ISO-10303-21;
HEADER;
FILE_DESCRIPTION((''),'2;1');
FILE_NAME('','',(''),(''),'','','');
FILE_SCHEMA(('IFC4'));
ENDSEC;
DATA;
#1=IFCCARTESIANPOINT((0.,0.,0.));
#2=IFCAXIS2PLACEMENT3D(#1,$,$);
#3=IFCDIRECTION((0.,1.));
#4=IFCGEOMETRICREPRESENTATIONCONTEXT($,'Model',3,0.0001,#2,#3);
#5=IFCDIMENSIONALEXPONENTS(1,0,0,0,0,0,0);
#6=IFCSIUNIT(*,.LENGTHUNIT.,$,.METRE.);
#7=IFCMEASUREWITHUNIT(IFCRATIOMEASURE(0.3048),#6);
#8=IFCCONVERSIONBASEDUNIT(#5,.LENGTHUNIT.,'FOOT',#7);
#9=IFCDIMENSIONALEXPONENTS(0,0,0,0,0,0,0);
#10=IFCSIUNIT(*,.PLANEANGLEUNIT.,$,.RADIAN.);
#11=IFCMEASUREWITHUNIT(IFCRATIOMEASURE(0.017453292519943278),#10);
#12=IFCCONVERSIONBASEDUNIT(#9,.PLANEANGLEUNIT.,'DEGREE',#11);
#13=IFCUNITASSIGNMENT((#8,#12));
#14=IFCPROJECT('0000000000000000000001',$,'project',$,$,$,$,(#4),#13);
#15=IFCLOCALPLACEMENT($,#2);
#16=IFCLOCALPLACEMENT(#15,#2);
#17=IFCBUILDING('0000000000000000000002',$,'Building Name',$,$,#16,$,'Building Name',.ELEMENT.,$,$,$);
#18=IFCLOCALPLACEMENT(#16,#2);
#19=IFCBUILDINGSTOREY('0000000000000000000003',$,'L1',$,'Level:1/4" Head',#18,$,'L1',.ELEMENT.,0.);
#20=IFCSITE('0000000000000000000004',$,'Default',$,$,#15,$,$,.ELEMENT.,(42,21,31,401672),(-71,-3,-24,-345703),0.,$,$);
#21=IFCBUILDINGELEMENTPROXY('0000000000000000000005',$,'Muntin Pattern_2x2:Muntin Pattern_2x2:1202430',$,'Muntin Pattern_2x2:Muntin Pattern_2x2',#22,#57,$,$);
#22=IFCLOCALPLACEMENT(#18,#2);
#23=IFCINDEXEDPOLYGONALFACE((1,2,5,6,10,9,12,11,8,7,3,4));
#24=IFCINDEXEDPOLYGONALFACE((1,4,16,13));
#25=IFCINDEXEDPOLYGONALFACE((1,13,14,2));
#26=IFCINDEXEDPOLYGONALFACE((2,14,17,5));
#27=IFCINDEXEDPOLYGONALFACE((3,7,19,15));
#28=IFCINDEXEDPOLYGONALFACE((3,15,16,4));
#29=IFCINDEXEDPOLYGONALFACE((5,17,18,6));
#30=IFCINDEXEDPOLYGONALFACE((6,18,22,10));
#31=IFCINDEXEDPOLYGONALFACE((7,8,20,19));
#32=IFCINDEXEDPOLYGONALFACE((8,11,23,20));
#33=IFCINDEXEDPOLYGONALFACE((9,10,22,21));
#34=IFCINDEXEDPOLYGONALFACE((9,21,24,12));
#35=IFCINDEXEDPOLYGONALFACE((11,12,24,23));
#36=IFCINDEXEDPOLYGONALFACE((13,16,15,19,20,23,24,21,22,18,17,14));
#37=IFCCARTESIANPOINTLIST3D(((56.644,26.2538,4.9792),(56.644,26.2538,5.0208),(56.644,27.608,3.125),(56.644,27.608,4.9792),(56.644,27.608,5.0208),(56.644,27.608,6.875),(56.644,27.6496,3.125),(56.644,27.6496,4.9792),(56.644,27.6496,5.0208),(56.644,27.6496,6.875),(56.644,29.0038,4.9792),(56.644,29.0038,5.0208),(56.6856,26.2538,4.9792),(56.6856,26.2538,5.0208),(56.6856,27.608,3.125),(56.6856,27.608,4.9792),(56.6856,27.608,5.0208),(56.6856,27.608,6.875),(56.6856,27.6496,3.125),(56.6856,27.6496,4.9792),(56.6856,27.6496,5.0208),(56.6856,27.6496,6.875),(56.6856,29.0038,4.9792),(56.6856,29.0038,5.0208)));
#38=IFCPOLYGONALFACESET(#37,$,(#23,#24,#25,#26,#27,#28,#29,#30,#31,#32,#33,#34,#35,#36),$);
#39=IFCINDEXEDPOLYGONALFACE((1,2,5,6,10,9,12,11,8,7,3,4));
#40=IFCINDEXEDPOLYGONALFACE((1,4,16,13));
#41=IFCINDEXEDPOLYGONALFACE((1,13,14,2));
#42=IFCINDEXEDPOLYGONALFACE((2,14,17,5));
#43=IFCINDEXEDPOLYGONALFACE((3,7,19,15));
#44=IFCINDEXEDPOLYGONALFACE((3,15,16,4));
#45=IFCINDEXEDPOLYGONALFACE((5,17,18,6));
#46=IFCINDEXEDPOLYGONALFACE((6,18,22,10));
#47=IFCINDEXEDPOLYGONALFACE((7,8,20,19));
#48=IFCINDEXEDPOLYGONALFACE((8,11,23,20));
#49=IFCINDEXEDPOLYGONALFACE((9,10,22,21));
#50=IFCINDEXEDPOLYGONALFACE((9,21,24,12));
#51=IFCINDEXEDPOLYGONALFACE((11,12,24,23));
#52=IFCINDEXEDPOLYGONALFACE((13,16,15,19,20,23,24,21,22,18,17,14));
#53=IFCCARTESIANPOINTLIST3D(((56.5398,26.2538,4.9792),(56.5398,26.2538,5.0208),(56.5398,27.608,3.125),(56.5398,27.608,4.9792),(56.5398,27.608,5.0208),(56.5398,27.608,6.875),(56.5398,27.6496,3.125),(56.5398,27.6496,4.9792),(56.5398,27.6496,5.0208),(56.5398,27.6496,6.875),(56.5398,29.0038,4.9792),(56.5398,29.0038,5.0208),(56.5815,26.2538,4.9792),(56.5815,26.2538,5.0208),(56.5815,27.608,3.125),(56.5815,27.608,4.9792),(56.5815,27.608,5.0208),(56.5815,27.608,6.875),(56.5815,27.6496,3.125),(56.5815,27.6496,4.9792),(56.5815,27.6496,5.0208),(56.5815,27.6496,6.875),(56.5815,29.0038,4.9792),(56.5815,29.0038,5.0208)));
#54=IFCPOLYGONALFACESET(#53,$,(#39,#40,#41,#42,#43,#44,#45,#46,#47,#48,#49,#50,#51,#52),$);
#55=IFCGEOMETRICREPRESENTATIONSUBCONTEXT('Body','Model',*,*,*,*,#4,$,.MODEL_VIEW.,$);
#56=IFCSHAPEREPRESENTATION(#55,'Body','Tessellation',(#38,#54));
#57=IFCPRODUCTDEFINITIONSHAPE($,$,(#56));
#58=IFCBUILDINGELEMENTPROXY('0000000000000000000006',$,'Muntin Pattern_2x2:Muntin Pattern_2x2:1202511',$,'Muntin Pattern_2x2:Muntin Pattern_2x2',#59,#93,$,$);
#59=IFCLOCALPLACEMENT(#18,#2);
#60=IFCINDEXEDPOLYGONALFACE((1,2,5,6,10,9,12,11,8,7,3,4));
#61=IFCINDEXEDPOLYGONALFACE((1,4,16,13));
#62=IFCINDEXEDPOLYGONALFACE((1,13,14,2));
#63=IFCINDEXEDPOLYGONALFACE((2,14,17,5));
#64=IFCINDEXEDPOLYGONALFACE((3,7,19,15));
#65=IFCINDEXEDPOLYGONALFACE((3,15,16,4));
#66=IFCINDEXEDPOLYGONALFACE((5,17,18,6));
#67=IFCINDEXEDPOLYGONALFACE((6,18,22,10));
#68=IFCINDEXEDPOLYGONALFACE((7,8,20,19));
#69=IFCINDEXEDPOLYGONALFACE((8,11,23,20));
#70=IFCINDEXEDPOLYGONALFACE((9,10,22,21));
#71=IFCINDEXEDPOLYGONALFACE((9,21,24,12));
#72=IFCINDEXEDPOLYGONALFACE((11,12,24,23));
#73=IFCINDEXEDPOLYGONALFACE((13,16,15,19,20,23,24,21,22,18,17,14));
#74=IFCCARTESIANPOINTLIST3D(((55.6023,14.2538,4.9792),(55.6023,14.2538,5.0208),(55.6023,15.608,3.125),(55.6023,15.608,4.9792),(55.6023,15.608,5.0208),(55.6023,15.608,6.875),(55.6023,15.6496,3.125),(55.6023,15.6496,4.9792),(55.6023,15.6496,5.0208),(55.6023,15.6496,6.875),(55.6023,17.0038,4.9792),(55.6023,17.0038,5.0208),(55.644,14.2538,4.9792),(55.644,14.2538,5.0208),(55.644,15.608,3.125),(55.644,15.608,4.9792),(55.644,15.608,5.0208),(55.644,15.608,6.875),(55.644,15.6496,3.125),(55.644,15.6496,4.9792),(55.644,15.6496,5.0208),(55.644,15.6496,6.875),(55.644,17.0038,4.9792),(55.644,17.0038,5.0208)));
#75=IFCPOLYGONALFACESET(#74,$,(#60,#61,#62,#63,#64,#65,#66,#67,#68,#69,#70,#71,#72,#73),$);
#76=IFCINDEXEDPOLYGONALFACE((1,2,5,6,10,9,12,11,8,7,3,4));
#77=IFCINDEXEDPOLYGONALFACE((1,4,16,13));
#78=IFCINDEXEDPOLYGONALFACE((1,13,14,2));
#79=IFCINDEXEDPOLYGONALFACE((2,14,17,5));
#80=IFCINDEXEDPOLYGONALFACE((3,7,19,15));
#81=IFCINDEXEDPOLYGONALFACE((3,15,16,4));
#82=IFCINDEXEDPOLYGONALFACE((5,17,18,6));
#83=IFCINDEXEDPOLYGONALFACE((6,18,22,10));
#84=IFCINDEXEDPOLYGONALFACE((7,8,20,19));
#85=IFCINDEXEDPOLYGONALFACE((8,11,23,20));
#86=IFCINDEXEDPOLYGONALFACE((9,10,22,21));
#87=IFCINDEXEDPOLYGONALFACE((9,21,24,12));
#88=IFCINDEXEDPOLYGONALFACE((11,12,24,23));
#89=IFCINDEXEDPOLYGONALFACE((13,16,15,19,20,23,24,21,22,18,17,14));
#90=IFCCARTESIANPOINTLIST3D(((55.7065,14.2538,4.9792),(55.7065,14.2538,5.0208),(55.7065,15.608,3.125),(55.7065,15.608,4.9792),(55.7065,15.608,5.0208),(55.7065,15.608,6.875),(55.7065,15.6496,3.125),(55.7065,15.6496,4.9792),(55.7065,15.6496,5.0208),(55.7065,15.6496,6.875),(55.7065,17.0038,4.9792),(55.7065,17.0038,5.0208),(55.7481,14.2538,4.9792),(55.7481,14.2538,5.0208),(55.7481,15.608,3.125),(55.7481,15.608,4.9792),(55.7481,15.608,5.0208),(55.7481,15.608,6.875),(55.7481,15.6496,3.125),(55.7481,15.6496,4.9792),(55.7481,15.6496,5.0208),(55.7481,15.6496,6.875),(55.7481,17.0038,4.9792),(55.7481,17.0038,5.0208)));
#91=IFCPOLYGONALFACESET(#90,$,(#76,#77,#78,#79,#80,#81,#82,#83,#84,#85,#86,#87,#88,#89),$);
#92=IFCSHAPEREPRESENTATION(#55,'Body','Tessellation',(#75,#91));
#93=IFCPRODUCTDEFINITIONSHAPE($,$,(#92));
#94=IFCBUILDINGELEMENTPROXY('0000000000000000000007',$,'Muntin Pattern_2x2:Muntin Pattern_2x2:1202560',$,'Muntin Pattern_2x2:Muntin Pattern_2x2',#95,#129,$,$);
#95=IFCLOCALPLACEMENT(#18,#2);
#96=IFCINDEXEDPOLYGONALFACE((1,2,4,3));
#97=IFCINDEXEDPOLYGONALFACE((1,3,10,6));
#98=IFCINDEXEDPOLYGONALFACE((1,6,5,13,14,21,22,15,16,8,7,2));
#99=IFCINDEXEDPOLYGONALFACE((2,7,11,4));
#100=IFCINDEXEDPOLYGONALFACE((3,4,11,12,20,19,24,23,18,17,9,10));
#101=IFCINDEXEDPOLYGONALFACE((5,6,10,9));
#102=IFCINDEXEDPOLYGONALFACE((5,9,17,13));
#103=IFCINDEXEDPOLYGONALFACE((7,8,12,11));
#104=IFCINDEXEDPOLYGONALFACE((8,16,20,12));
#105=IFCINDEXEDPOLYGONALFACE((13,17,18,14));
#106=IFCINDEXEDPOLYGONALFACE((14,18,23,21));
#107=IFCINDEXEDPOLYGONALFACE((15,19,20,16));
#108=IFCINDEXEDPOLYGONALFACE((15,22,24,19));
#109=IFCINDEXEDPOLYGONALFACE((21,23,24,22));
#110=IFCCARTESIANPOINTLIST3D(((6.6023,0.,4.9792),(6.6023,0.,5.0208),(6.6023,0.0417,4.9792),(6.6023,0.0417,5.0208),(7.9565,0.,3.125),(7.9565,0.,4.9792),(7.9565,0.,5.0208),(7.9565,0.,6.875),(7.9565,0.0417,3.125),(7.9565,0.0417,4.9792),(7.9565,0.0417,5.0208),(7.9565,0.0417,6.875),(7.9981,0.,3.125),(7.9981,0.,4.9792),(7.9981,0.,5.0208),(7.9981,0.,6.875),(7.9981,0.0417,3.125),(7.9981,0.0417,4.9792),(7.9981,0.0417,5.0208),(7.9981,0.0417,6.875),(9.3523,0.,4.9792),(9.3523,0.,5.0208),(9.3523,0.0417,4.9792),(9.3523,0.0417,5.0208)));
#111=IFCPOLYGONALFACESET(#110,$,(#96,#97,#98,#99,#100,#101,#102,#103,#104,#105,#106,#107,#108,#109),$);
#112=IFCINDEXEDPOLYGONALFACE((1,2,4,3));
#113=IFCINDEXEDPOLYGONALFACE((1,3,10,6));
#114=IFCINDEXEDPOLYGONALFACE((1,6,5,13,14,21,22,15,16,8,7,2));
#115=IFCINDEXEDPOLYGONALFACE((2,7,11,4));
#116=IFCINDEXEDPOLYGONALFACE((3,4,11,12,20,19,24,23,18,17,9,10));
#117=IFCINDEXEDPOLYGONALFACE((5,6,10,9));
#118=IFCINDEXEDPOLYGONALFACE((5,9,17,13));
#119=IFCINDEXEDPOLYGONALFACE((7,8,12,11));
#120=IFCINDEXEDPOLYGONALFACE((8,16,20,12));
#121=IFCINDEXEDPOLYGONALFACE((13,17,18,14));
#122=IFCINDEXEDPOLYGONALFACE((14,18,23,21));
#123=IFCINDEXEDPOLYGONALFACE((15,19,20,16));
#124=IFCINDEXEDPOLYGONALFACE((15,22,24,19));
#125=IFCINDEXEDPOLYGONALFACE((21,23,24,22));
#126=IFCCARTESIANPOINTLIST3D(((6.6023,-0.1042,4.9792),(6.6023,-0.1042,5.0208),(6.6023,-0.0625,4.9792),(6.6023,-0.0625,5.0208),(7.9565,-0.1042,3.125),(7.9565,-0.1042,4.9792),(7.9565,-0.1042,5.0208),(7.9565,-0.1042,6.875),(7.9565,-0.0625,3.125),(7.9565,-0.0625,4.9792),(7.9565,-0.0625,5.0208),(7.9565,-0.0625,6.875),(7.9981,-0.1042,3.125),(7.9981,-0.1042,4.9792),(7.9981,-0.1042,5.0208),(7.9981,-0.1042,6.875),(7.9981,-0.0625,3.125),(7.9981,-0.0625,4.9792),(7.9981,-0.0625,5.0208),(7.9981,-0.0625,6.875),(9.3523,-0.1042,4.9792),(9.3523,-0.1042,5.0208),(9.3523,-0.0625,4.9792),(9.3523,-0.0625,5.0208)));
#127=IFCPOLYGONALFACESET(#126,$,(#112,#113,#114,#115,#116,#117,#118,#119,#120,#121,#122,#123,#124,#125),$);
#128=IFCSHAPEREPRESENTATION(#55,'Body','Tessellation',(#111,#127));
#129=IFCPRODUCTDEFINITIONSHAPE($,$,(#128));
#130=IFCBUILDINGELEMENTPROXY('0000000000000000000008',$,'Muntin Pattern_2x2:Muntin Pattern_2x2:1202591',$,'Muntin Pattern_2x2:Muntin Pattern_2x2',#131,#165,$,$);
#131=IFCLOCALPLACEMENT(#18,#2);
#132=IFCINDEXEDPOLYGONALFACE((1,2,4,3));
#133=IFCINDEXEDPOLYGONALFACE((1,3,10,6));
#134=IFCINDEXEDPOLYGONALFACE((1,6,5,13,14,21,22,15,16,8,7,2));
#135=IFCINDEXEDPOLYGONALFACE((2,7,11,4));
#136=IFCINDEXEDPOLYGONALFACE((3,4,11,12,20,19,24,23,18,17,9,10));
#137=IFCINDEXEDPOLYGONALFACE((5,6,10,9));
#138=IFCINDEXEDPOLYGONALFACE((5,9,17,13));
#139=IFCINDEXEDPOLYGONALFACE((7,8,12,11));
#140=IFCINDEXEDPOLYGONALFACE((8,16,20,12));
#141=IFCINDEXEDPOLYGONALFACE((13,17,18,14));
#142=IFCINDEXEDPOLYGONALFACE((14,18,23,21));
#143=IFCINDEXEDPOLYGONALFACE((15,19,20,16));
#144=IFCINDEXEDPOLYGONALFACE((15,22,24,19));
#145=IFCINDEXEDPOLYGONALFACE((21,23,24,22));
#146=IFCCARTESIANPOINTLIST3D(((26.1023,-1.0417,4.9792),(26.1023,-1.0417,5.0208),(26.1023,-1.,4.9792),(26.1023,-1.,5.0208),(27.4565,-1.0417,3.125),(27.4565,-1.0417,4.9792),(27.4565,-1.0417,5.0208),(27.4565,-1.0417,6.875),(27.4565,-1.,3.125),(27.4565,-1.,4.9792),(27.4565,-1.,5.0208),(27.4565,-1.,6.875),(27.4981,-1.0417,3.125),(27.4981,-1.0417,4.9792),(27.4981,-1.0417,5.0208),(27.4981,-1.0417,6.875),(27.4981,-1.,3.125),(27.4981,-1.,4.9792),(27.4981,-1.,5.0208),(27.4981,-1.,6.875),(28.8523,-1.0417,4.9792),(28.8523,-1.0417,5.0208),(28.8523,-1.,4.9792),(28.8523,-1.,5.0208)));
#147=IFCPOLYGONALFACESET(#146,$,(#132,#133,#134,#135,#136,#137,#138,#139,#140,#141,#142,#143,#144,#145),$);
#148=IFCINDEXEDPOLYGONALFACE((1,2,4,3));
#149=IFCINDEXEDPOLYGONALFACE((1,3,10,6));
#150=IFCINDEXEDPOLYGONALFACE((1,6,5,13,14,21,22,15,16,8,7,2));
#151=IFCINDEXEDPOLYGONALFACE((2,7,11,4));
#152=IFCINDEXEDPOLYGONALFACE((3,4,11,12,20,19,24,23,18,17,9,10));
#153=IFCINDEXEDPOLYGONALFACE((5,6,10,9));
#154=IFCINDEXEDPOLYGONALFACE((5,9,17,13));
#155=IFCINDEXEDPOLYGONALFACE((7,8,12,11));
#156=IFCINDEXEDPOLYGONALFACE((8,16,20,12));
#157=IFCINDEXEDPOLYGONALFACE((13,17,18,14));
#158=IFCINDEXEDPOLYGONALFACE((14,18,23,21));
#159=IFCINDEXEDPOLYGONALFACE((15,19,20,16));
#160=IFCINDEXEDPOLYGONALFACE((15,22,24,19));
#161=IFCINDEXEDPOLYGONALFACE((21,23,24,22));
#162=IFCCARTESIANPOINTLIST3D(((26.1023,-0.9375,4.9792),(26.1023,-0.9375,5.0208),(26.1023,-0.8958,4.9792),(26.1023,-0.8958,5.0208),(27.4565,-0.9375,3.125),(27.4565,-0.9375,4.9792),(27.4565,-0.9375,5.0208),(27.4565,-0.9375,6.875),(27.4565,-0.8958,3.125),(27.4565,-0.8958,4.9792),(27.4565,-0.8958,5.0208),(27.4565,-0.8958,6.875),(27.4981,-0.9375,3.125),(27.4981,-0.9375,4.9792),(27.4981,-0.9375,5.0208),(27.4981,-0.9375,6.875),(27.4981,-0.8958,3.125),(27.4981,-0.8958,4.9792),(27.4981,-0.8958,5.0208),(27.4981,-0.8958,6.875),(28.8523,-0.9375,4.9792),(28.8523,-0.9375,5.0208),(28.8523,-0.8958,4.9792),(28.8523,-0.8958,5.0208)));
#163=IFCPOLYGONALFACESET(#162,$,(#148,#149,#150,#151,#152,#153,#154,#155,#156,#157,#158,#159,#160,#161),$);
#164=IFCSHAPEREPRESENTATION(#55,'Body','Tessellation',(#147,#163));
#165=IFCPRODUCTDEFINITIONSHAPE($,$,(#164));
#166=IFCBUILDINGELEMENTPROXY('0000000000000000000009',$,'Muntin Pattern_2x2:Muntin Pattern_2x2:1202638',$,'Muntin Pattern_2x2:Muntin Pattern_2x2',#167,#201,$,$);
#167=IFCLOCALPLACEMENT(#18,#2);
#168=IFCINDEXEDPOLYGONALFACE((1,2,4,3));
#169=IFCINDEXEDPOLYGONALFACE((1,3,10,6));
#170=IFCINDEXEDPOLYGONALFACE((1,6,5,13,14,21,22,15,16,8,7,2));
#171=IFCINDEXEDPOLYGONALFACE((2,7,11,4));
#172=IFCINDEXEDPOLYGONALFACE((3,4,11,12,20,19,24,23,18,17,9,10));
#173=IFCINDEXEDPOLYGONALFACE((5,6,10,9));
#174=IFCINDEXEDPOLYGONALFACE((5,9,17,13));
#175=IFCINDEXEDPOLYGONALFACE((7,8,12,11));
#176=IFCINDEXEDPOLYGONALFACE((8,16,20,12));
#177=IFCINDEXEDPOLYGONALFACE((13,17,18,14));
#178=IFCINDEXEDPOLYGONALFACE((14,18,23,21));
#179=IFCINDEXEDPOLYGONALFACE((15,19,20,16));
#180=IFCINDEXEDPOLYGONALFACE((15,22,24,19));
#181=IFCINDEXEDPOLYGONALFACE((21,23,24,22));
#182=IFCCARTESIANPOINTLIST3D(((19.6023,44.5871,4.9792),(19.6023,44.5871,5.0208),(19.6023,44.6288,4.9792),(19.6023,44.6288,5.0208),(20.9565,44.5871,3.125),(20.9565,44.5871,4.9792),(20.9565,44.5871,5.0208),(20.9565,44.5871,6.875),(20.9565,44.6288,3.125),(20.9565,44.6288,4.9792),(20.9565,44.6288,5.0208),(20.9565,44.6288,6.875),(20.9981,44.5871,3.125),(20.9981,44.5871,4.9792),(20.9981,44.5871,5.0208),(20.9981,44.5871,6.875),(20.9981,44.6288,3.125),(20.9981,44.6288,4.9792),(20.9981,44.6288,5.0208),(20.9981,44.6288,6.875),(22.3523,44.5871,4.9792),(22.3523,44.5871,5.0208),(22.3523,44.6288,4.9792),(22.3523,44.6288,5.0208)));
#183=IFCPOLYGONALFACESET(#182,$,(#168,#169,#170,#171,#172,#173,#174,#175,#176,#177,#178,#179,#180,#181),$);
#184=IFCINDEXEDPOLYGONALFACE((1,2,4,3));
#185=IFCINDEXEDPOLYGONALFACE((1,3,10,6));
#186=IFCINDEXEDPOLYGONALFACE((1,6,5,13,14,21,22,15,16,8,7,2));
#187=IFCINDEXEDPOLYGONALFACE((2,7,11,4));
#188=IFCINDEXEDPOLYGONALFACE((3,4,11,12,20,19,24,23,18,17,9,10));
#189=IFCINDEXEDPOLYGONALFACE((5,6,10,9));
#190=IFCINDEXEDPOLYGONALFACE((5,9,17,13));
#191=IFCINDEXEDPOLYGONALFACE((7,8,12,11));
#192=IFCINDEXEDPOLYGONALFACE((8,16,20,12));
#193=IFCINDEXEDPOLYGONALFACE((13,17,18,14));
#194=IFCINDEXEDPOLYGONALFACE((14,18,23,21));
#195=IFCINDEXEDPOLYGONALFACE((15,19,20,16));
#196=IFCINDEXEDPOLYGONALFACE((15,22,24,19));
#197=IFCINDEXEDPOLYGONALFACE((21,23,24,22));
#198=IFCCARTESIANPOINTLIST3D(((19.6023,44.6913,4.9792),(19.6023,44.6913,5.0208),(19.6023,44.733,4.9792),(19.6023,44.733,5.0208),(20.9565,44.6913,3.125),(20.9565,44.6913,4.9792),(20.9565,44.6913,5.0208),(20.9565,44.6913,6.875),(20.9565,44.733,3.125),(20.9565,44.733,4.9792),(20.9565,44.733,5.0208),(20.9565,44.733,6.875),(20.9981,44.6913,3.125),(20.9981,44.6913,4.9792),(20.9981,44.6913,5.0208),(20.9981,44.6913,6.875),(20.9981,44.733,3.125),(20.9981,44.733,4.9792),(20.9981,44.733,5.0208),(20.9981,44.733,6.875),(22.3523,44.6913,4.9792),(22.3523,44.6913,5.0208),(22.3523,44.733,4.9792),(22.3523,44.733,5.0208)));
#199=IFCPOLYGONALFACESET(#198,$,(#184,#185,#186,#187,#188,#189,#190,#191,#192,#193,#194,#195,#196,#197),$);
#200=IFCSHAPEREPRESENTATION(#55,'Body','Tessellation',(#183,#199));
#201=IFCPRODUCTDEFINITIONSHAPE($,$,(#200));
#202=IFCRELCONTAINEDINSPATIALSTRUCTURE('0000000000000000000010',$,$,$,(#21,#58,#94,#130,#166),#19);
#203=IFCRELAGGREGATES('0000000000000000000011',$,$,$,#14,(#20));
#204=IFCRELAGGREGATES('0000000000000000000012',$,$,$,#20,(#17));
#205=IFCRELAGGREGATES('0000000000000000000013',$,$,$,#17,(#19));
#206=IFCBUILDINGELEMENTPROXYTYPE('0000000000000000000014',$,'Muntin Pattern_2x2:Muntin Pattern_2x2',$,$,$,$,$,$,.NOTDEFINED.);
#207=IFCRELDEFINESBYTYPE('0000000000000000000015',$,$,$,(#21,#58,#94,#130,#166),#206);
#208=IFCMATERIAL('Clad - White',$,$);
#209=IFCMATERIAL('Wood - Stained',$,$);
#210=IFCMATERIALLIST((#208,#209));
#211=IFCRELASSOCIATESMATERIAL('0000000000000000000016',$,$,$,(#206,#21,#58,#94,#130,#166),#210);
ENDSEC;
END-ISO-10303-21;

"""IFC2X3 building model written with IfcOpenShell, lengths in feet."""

from ifc_helpers import new_model, entity, si_unit, converted_unit, direction, frame, origin, place, context, subcontext, project, spatial, polyline, outline, extrude, source, transform, mapped, material, material_list, type_object, type_shapes, element, save


model = new_model("IFC2X3")

# Units and contexts
model_context = context("Model", 3, precision=0.0001, world=origin(), true_north=direction((0.0, 1.0)))
body_context = subcontext(model_context, "Body", "Model", "MODEL_VIEW")
ifc_project = project(units=[converted_unit("LENGTHUNIT", "FOOT", entity("IfcRatioMeasure", 0.3048), si_unit("LENGTHUNIT", "METRE"), dimensions=[1, 0, 0, 0, 0, 0, 0]), converted_unit("PLANEANGLEUNIT", "DEGREE", entity("IfcRatioMeasure", 0.017453292519943278), si_unit("PLANEANGLEUNIT", "RADIAN"), dimensions=[0, 0, 0, 0, 0, 0, 0])], contexts=[model_context])

# Site, building, storey
site_placement = place(None, origin())
site = spatial("IfcSite", under=ifc_project, at=site_placement, Name="Default", CompositionType="ELEMENT", RefLatitude=(42, 21, 31, 401672), RefLongitude=(-71, -3, -24, -345703), RefElevation=0.0)
building_placement = place(site_placement, origin())
building = spatial("IfcBuilding", under=site, at=building_placement, Name="Building Name", LongName="Building Name", CompositionType="ELEMENT")
storey_placement = place(building_placement, origin())
storey = spatial("IfcBuildingStorey", under=building, at=storey_placement, Name="L1", ObjectType="Level:1/4\" Head", LongName="L1", CompositionType="ELEMENT", Elevation=0.0)

# Building element proxies
ifc_material_1 = material(Name="Clad - White")
ifc_material_2 = material(Name="Wood - Stained")
ifc_material_list = material_list([ifc_material_1, ifc_material_2])
building_element_proxy_type_1 = type_object("IfcBuildingElementProxyType", Name="Muntin Pattern_2x2:Muntin Pattern_2x2", PredefinedType="NOTDEFINED", material=ifc_material_list)
shared_shape_1 = source(origin(), body_context, "Body", "SweptSolid", [
    extrude(outline(polyline([(0.0208, -0.0208), (1.875, -0.0208), (1.875, 0.0208), (0.0208, 0.0208), (0.0208, 1.375), (-0.0208, 1.375), (-0.0208, 0.0208), (-1.875, 0.0208), (-1.875, -0.0208), (-0.0208, -0.0208), (-0.0208, -1.375), (0.0208, -1.375), (0.0208, -0.0208)])), frame((0.0, -0.0729, 1.875), z_axis=(0.0, 1.0, 0.0), x_axis=(0.0, 0.0, 1.0)), (0.0, 0.0, 1.0), 0.0417),
    extrude(outline(polyline([(0.0208, -0.0208), (1.875, -0.0208), (1.875, 0.0208), (0.0208, 0.0208), (0.0208, 1.375), (-0.0208, 1.375), (-0.0208, 0.0208), (-1.875, 0.0208), (-1.875, -0.0208), (-0.0208, -0.0208), (-0.0208, -1.375), (0.0208, -1.375), (0.0208, -0.0208)])), frame((0.0, 0.0313, 1.875), z_axis=(0.0, 1.0, 0.0), x_axis=(0.0, 0.0, 1.0)), (0.0, 0.0, 1.0), 0.0417),
])
type_shapes(building_element_proxy_type_1, [shared_shape_1])
for number, where, z_axis, x_axis, name in (
    (1, (56.6127, 27.6288, 3.125), (0.0, 0.0, 1.0), (0.0, 1.0, 0.0), "Muntin Pattern_2x2:Muntin Pattern_2x2:1202430"),
    (2, (55.6752, 15.6288, 3.125), (0.0, 0.0, 1.0), (0.0, -1.0, 0.0), "Muntin Pattern_2x2:Muntin Pattern_2x2:1202511"),
    (3, (7.9773, -0.0312, 3.125), (0.0, 0.0, 1.0), (-1.0, 0.0, 0.0), "Muntin Pattern_2x2:Muntin Pattern_2x2:1202560"),
):
    element("IfcBuildingElementProxy", number, at=place(storey_placement, frame(where, z_axis=z_axis, x_axis=x_axis)), inside=storey, type_object=building_element_proxy_type_1, material=ifc_material_list, Name=name, ObjectType="Muntin Pattern_2x2:Muntin Pattern_2x2", context=body_context, shape_type="MappedRepresentation", body=[
        mapped(shared_shape_1, transform((0.0, 0.0, 0.0), scale=1.0)),
    ])
for number, where, name in (
    (4, (27.4773, -0.9688, 3.125), "Muntin Pattern_2x2:Muntin Pattern_2x2:1202591"),
    (5, (20.9773, 44.66, 3.125), "Muntin Pattern_2x2:Muntin Pattern_2x2:1202638"),
):
    element("IfcBuildingElementProxy", number, at=place(storey_placement, frame(where)), inside=storey, type_object=building_element_proxy_type_1, material=ifc_material_list, Name=name, ObjectType="Muntin Pattern_2x2:Muntin Pattern_2x2", context=body_context, shape_type="MappedRepresentation", body=[
        mapped(shared_shape_1, transform((0.0, 0.0, 0.0), scale=1.0)),
    ])

save(model, "model.ifc")
